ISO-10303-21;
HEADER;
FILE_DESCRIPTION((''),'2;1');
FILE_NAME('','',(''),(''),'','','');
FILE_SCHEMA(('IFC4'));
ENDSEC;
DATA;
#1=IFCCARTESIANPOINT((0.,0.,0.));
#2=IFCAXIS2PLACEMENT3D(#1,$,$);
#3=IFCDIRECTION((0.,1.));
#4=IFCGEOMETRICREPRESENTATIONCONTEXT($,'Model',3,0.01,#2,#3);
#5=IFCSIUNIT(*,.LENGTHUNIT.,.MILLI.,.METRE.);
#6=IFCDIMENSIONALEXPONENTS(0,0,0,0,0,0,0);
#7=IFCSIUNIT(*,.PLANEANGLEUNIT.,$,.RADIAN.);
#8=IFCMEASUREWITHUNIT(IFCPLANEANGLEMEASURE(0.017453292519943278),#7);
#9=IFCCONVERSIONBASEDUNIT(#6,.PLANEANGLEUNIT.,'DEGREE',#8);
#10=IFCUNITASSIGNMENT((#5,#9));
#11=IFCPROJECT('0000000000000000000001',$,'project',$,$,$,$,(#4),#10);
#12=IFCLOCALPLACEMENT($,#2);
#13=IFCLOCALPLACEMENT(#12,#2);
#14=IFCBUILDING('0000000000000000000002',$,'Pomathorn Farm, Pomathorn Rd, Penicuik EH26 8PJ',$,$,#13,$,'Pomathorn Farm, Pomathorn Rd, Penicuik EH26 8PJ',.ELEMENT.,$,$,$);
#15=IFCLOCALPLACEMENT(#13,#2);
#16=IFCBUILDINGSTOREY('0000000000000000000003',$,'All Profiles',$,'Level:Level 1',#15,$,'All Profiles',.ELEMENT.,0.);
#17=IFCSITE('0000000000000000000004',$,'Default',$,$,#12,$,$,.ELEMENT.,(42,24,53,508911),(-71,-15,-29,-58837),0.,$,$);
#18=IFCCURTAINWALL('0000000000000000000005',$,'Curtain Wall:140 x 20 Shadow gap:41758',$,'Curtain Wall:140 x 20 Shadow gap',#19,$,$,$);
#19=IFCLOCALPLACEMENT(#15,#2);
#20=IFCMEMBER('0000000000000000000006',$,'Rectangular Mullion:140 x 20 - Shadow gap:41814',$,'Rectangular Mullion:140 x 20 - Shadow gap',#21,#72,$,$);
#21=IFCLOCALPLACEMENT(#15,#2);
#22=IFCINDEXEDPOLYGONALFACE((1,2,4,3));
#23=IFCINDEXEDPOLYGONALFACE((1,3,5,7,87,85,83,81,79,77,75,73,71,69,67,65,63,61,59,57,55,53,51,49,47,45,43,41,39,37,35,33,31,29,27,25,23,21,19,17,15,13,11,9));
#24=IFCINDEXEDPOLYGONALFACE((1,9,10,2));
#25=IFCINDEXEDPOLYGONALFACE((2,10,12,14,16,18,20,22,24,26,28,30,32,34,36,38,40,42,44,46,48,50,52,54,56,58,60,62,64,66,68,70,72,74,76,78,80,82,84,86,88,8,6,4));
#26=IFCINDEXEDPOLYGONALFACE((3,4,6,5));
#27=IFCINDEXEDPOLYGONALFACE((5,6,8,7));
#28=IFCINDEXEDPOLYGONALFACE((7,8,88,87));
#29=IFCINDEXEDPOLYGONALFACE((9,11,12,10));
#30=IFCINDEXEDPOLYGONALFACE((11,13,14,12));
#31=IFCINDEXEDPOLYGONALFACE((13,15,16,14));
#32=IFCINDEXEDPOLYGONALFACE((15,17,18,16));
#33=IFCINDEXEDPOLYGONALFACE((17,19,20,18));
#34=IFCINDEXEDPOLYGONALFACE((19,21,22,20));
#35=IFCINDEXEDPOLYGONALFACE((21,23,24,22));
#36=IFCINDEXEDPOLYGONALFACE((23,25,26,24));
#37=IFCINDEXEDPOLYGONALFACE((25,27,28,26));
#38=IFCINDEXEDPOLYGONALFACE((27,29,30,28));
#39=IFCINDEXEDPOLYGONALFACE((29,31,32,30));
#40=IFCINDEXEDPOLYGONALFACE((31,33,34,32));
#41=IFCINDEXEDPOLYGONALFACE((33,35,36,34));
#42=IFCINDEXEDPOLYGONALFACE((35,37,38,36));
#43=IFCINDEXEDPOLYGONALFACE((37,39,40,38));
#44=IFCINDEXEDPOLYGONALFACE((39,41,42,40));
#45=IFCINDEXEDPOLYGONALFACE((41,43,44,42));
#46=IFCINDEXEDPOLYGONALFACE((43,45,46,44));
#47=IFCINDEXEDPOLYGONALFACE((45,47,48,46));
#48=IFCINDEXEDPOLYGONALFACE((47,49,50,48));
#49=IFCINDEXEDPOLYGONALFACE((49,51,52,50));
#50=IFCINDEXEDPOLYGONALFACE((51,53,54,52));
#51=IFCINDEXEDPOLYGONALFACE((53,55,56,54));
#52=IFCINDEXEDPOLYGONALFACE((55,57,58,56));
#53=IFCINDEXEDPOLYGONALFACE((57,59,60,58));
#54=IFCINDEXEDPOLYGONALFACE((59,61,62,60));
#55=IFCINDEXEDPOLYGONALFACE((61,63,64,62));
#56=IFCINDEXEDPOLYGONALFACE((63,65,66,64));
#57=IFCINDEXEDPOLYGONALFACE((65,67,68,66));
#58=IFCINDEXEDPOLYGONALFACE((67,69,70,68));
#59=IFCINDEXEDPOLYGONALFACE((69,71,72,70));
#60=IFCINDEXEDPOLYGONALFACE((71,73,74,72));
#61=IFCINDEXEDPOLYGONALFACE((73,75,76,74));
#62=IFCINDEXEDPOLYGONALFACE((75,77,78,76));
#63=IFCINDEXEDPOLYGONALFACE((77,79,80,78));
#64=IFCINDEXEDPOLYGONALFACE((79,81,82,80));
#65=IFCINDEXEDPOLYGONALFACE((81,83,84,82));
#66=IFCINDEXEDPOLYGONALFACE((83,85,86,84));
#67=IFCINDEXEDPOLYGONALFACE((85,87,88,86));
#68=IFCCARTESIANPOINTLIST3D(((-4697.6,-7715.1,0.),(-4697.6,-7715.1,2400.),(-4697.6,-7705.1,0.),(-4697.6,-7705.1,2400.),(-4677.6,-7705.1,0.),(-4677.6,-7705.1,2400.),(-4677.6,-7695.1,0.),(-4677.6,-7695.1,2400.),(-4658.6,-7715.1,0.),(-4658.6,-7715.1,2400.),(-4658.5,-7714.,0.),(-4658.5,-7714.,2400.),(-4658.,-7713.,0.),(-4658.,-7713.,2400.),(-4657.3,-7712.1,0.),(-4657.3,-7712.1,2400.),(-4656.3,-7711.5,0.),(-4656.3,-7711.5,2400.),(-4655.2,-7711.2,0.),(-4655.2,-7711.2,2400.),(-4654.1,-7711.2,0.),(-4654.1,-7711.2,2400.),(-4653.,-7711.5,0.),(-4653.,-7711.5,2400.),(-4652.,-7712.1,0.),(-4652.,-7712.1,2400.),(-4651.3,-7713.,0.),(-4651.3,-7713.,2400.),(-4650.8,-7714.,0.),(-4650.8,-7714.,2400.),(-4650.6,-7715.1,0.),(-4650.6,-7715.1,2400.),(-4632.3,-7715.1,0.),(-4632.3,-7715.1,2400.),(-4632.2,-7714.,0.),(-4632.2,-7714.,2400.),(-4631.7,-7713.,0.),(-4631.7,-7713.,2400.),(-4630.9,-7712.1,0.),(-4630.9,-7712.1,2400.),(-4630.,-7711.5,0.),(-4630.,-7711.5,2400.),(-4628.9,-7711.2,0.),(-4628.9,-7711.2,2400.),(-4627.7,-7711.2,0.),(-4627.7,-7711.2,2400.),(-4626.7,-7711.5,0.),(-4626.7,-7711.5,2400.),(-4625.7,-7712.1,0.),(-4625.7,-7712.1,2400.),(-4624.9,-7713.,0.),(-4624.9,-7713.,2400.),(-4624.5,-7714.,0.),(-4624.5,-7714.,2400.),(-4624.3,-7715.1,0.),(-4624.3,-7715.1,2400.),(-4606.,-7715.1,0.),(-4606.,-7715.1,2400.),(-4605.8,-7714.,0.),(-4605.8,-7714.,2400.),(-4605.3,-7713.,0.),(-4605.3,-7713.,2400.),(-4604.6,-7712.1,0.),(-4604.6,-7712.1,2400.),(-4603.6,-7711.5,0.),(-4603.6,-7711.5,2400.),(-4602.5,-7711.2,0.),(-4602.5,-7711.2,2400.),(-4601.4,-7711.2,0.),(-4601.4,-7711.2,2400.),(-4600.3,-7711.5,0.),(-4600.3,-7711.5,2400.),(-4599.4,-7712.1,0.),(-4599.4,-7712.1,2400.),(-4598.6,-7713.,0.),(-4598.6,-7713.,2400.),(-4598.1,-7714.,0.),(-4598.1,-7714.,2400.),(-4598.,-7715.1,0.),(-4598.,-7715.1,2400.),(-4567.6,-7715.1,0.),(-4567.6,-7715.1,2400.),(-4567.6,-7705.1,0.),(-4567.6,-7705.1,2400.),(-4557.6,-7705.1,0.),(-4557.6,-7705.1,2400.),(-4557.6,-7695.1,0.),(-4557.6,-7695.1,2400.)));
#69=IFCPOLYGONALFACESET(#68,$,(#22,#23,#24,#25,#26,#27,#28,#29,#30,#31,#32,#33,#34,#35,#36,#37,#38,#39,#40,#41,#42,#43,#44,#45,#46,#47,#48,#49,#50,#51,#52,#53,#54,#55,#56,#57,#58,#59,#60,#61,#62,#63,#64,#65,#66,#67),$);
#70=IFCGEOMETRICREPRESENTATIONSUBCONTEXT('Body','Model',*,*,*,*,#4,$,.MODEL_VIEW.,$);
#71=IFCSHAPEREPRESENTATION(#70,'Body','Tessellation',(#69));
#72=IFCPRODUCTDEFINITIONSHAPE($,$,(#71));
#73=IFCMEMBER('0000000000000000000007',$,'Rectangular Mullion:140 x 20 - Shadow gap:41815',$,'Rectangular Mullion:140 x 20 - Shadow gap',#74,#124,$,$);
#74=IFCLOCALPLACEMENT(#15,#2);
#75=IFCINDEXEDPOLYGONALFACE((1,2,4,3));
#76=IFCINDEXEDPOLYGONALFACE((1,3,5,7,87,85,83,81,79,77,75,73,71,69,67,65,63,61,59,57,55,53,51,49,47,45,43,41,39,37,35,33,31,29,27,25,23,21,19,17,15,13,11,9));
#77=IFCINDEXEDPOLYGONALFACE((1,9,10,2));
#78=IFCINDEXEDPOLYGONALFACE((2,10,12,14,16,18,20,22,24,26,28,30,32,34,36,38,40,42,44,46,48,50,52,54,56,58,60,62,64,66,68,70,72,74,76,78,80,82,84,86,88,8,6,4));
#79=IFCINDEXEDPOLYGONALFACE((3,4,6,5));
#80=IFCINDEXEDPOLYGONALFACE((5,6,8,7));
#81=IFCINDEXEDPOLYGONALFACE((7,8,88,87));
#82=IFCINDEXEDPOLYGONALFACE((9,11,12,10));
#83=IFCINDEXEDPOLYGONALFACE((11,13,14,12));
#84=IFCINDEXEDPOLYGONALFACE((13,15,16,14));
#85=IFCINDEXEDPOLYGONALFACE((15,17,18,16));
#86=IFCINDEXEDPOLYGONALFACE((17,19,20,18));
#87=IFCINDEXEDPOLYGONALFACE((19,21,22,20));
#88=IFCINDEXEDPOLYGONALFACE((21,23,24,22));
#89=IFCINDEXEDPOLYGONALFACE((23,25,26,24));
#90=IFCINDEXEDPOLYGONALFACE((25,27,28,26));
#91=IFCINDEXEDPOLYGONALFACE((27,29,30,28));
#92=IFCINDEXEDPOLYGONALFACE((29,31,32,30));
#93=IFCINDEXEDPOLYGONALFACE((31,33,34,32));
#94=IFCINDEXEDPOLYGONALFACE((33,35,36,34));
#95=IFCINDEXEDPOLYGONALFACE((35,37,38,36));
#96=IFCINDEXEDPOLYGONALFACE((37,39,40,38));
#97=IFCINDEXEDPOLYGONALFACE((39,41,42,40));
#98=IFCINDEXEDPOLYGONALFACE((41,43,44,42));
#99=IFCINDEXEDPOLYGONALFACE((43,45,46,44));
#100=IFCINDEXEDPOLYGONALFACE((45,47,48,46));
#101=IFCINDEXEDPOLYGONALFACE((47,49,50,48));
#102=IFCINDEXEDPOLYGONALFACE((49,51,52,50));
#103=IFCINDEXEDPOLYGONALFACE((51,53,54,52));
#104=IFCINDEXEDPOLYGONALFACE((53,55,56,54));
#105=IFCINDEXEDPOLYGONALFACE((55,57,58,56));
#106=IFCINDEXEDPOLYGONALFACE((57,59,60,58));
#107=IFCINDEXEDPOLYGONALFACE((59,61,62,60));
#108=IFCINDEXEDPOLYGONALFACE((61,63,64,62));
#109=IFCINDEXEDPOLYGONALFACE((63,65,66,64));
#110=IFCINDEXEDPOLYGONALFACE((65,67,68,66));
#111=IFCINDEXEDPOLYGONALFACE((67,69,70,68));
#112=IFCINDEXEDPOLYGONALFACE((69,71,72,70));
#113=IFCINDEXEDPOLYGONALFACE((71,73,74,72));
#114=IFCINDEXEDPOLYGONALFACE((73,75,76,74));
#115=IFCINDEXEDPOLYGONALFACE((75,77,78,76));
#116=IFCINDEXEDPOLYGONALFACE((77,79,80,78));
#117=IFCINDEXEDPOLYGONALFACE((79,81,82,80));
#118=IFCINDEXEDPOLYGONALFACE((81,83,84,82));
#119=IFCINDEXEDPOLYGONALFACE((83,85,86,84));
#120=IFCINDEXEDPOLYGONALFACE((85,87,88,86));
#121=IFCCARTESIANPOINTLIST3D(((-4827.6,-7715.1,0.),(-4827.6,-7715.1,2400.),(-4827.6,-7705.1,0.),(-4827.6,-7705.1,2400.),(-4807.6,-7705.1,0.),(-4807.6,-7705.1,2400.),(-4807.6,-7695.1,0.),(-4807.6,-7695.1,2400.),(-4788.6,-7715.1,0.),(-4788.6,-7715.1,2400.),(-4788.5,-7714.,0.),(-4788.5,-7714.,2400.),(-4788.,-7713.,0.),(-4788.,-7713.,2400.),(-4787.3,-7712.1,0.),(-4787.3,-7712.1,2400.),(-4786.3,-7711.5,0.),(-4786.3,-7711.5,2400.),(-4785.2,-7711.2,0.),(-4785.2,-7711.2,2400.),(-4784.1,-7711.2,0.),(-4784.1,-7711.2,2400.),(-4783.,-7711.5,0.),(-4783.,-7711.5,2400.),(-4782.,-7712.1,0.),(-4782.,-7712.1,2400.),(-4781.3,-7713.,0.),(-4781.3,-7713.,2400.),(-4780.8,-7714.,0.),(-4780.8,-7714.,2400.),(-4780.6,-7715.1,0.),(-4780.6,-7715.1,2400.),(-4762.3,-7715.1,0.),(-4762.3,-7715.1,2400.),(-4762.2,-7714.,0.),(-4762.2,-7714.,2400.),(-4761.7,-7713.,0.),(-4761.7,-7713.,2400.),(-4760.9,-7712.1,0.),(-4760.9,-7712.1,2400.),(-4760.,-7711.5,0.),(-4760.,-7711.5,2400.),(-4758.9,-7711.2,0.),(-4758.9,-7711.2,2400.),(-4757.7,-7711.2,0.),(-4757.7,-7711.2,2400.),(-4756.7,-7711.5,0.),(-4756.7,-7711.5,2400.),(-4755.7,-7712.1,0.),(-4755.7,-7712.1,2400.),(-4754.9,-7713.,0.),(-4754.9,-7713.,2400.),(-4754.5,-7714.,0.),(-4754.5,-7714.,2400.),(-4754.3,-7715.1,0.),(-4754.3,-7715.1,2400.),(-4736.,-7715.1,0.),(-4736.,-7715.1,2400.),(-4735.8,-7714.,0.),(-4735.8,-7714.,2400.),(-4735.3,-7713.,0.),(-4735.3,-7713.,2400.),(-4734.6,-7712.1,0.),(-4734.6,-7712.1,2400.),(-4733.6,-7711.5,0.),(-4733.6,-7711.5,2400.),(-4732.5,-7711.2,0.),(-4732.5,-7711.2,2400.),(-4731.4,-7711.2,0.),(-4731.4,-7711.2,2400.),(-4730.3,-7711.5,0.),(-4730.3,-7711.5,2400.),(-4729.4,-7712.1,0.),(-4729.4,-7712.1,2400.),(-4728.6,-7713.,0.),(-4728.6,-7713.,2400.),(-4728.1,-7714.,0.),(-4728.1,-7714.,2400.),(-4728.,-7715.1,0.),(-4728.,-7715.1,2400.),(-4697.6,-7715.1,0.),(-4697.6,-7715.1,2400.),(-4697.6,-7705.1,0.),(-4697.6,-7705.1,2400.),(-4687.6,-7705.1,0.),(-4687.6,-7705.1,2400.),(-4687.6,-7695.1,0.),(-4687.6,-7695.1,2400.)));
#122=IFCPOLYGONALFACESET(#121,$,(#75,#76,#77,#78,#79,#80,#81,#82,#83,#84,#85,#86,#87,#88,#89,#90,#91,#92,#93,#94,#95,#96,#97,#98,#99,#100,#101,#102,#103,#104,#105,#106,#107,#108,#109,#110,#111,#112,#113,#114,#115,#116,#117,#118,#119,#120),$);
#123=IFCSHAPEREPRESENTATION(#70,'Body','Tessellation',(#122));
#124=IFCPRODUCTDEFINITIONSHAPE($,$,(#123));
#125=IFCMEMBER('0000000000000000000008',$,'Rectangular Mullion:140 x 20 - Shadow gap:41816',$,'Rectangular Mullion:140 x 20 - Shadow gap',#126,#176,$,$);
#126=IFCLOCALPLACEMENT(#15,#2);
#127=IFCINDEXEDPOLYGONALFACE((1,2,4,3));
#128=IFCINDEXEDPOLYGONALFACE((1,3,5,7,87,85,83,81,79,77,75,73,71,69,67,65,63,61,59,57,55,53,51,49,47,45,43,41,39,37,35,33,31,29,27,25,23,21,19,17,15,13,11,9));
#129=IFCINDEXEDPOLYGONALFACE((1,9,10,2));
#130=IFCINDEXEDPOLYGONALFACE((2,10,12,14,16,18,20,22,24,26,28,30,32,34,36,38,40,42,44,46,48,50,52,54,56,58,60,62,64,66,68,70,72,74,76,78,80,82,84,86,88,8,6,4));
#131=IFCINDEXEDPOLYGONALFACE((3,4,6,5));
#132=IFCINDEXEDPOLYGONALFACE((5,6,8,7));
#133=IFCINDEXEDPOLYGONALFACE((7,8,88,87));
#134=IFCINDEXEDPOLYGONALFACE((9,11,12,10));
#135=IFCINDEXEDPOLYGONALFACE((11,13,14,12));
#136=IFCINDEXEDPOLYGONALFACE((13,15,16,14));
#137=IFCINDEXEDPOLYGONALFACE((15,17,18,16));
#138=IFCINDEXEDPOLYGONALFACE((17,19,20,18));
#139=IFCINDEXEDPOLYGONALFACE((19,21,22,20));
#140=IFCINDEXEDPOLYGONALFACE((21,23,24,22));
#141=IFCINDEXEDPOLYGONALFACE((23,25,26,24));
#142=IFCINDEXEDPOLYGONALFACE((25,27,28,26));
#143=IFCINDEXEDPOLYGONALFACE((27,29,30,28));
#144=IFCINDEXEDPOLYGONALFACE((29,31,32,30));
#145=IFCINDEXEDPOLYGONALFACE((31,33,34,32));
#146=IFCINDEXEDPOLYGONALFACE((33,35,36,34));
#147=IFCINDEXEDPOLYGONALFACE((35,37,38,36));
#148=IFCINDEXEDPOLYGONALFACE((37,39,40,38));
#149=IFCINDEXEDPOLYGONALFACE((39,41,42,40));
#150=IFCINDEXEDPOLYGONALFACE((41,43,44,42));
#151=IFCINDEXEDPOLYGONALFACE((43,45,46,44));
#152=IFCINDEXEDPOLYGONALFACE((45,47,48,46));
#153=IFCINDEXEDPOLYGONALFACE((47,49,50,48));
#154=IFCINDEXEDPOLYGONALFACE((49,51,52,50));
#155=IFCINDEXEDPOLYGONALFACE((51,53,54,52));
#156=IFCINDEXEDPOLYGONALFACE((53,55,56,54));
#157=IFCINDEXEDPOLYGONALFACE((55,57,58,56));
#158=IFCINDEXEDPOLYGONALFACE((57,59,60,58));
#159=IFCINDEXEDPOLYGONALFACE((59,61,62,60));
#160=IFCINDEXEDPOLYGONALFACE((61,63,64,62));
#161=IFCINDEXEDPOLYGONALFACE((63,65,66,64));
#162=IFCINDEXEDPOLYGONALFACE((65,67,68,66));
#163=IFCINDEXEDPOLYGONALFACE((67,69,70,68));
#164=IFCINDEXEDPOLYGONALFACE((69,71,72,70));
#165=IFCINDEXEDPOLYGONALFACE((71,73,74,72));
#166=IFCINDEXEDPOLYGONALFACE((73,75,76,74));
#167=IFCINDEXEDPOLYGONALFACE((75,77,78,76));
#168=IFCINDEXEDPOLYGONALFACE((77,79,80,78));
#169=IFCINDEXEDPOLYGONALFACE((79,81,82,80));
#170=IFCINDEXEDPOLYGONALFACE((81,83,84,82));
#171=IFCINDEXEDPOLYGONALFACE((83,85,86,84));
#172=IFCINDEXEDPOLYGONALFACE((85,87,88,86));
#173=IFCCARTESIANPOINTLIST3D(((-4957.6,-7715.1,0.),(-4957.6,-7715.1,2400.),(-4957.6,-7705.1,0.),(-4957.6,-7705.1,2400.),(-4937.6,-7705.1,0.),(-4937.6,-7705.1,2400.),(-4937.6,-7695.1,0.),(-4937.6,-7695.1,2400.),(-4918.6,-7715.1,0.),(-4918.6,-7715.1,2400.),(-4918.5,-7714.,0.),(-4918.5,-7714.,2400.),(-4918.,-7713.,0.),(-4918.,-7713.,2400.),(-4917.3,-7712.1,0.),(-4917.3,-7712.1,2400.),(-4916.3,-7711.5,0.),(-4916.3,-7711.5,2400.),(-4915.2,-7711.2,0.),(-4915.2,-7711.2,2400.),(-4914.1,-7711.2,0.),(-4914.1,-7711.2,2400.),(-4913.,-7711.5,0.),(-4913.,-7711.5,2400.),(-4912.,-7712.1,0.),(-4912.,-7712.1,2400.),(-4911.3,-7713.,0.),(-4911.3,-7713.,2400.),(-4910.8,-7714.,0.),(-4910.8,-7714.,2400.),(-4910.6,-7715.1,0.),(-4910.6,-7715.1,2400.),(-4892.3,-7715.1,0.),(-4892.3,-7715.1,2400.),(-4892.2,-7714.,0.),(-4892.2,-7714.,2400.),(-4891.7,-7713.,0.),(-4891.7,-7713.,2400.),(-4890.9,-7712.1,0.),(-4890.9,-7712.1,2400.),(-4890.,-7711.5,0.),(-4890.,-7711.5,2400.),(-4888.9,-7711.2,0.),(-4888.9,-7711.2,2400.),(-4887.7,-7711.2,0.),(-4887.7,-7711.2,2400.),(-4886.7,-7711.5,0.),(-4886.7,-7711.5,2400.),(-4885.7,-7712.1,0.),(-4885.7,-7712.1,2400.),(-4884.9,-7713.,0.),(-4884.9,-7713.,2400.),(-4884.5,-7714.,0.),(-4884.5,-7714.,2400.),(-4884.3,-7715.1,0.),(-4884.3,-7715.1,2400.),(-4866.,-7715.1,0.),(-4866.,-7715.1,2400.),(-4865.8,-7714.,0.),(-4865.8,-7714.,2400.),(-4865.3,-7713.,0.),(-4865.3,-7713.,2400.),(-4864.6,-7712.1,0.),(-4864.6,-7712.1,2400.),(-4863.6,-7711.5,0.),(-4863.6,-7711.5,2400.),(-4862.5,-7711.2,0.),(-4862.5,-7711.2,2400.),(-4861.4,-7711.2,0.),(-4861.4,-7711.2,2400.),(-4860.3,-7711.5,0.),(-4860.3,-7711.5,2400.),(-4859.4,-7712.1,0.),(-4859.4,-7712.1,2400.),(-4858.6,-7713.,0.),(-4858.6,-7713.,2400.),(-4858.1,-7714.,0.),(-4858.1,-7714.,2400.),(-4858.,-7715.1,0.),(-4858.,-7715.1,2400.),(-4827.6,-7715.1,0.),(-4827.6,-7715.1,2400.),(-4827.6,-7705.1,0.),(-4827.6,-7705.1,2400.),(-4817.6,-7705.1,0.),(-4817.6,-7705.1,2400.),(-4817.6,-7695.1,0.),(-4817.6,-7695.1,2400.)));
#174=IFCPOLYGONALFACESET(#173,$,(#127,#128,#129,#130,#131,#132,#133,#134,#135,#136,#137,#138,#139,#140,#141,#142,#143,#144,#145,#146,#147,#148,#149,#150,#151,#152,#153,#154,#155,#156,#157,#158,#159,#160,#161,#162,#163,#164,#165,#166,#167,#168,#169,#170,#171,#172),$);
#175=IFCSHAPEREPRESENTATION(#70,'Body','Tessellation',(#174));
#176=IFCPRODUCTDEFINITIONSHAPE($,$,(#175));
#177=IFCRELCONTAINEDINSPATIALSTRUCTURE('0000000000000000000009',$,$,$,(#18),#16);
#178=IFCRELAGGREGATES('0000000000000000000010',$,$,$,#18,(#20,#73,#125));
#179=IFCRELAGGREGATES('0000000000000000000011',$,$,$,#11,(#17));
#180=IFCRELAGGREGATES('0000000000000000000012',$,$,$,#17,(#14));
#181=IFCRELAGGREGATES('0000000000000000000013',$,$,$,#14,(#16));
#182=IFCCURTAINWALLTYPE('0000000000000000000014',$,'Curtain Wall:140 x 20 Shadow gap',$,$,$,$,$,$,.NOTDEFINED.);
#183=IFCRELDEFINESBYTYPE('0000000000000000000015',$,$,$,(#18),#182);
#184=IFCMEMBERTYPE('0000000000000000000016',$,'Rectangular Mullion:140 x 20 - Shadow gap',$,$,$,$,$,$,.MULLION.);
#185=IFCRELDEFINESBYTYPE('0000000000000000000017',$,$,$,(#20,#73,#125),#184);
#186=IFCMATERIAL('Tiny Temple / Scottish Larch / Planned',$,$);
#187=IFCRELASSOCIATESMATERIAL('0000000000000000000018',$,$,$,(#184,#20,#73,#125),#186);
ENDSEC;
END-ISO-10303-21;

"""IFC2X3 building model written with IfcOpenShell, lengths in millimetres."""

from ifc_helpers import new_model, entity, si_unit, converted_unit, direction, frame, frame_2d, origin, place, context, subcontext, project, spatial, polyline, circle_curve, parameter, trimmed, segment, composite_curve, outline, extrude, source, transform, mapped, material, type_object, type_shapes, element, aggregate, save


model = new_model("IFC2X3")

# Units and contexts
model_context = context("Model", 3, precision=0.01, world=origin(), true_north=direction((0.0, 1.0)))
body_context = subcontext(model_context, "Body", "Model", "MODEL_VIEW")
ifc_project = project(units=[si_unit("LENGTHUNIT", "METRE", prefix="MILLI"), converted_unit("PLANEANGLEUNIT", "DEGREE", entity("IfcPlaneAngleMeasure", 0.017453292519943278), si_unit("PLANEANGLEUNIT", "RADIAN"), dimensions=[0, 0, 0, 0, 0, 0, 0])], contexts=[model_context])

# Site, building, storey
site_placement = place(None, origin())
site = spatial("IfcSite", under=ifc_project, at=site_placement, Name="Default", CompositionType="ELEMENT", RefLatitude=(42, 24, 53, 508911), RefLongitude=(-71, -15, -29, -58837), RefElevation=0.0)
building_placement = place(site_placement, origin())
building = spatial("IfcBuilding", under=site, at=building_placement, Name="Pomathorn Farm, Pomathorn Rd, Penicuik EH26 8PJ", LongName="Pomathorn Farm, Pomathorn Rd, Penicuik EH26 8PJ", CompositionType="ELEMENT")
storey_placement = place(building_placement, origin())
storey = spatial("IfcBuildingStorey", under=building, at=storey_placement, Name="All Profiles", ObjectType="Level:Level 1", LongName="All Profiles", CompositionType="ELEMENT", Elevation=0.0)

# Curtain wall, members
ifc_material = material(Name="Tiny Temple / Scottish Larch / Planned")
curtain_wall_type_1 = type_object("IfcCurtainWallType", Name="Curtain Wall:140 x 20 Shadow gap", PredefinedType="NOTDEFINED")
curtain_wall_1_placement = place(storey_placement, origin())
curtain_wall_1 = element("IfcCurtainWall", 1, at=curtain_wall_1_placement, inside=storey, type_object=curtain_wall_type_1, Name="Curtain Wall:140 x 20 Shadow gap:41758", ObjectType="Curtain Wall:140 x 20 Shadow gap")
member_type_1 = type_object("IfcMemberType", Name="Rectangular Mullion:140 x 20 - Shadow gap", PredefinedType="MULLION", material=ifc_material)
shared_shape_1 = source(origin(), body_context, "Body", "SweptSolid", [
    extrude(outline(composite_curve([segment(polyline([(28.5, -5.7), (58.9, -5.7)]), True, "CONTINUOUS"), segment(polyline([(58.9, -5.7), (58.9, 4.3)]), True, "CONTINUOUS"), segment(polyline([(58.9, 4.3), (68.9, 4.3)]), True, "CONTINUOUS"), segment(polyline([(68.9, 4.3), (68.9, 14.3)]), True, "CONTINUOUS"), segment(polyline([(68.9, 14.3), (-51.1, 14.3)]), True, "CONTINUOUS"), segment(polyline([(-51.1, 14.3), (-51.1, 4.3)]), True, "CONTINUOUS"), segment(polyline([(-51.1, 4.3), (-71.1, 4.3)]), True, "CONTINUOUS"), segment(polyline([(-71.1, 4.3), (-71.1, -5.7)]), True, "CONTINUOUS"), segment(polyline([(-71.1, -5.7), (-32.1, -5.7)]), True, "CONTINUOUS"), segment(trimmed(circle_curve(frame_2d((-28.1, -5.7), x_axis=(1.0, 0.0)), 4.0), [parameter(360.0)], [parameter(180.0)], True, "PARAMETER"), False, "CONTINUOUS"), segment(polyline([(-24.1, -5.7), (-5.8, -5.7)]), True, "CONTINUOUS"), segment(trimmed(circle_curve(frame_2d((-1.8, -5.7), x_axis=(1.0, 0.0)), 4.0), [parameter(360.0)], [parameter(180.0)], True, "PARAMETER"), False, "CONTINUOUS"), segment(polyline([(2.2, -5.7), (20.5, -5.7)]), True, "CONTINUOUS"), segment(trimmed(circle_curve(frame_2d((24.5, -5.7), x_axis=(1.0, 0.0)), 4.0), [parameter(360.0)], [parameter(180.0)], True, "PARAMETER"), False, "CONTINUOUS")], self_intersect=False)), frame((-68.9, -5.7, -2400.0), z_axis=(0.0, 0.0, -1.0), x_axis=(1.0, 0.0, 0.0)), (0.0, 0.0, -1.0), 2400.0),
])
type_shapes(member_type_1, [shared_shape_1])
member_1_placement = place(curtain_wall_1_placement, frame((-4557.6, -7715.1, 0.0), z_axis=(0.0, 0.0, -1.0), x_axis=(1.0, 0.0, 0.0)))
member_1 = element("IfcMember", 2, at=member_1_placement, type_object=member_type_1, material=ifc_material, Name="Rectangular Mullion:140 x 20 - Shadow gap:41814", ObjectType="Rectangular Mullion:140 x 20 - Shadow gap", context=body_context, shape_type="MappedRepresentation", body=[
    mapped(shared_shape_1, transform((0.0, 0.0, 0.0), scale=1.0)),
])
member_2_placement = place(curtain_wall_1_placement, frame((-4687.6, -7715.1, 0.0), z_axis=(0.0, 0.0, -1.0), x_axis=(1.0, 0.0, 0.0)))
member_2 = element("IfcMember", 3, at=member_2_placement, type_object=member_type_1, material=ifc_material, Name="Rectangular Mullion:140 x 20 - Shadow gap:41815", ObjectType="Rectangular Mullion:140 x 20 - Shadow gap", context=body_context, shape_type="MappedRepresentation", body=[
    mapped(shared_shape_1, transform((0.0, 0.0, 0.0), scale=1.0)),
])
member_3_placement = place(curtain_wall_1_placement, frame((-4817.6, -7715.1, 0.0), z_axis=(0.0, 0.0, -1.0), x_axis=(1.0, 0.0, 0.0)))
member_3 = element("IfcMember", 4, at=member_3_placement, type_object=member_type_1, material=ifc_material, Name="Rectangular Mullion:140 x 20 - Shadow gap:41816", ObjectType="Rectangular Mullion:140 x 20 - Shadow gap", context=body_context, shape_type="MappedRepresentation", body=[
    mapped(shared_shape_1, transform((0.0, 0.0, 0.0), scale=1.0)),
])
aggregate(curtain_wall_1, [member_1, member_2, member_3])

save(model, "model.ifc")
